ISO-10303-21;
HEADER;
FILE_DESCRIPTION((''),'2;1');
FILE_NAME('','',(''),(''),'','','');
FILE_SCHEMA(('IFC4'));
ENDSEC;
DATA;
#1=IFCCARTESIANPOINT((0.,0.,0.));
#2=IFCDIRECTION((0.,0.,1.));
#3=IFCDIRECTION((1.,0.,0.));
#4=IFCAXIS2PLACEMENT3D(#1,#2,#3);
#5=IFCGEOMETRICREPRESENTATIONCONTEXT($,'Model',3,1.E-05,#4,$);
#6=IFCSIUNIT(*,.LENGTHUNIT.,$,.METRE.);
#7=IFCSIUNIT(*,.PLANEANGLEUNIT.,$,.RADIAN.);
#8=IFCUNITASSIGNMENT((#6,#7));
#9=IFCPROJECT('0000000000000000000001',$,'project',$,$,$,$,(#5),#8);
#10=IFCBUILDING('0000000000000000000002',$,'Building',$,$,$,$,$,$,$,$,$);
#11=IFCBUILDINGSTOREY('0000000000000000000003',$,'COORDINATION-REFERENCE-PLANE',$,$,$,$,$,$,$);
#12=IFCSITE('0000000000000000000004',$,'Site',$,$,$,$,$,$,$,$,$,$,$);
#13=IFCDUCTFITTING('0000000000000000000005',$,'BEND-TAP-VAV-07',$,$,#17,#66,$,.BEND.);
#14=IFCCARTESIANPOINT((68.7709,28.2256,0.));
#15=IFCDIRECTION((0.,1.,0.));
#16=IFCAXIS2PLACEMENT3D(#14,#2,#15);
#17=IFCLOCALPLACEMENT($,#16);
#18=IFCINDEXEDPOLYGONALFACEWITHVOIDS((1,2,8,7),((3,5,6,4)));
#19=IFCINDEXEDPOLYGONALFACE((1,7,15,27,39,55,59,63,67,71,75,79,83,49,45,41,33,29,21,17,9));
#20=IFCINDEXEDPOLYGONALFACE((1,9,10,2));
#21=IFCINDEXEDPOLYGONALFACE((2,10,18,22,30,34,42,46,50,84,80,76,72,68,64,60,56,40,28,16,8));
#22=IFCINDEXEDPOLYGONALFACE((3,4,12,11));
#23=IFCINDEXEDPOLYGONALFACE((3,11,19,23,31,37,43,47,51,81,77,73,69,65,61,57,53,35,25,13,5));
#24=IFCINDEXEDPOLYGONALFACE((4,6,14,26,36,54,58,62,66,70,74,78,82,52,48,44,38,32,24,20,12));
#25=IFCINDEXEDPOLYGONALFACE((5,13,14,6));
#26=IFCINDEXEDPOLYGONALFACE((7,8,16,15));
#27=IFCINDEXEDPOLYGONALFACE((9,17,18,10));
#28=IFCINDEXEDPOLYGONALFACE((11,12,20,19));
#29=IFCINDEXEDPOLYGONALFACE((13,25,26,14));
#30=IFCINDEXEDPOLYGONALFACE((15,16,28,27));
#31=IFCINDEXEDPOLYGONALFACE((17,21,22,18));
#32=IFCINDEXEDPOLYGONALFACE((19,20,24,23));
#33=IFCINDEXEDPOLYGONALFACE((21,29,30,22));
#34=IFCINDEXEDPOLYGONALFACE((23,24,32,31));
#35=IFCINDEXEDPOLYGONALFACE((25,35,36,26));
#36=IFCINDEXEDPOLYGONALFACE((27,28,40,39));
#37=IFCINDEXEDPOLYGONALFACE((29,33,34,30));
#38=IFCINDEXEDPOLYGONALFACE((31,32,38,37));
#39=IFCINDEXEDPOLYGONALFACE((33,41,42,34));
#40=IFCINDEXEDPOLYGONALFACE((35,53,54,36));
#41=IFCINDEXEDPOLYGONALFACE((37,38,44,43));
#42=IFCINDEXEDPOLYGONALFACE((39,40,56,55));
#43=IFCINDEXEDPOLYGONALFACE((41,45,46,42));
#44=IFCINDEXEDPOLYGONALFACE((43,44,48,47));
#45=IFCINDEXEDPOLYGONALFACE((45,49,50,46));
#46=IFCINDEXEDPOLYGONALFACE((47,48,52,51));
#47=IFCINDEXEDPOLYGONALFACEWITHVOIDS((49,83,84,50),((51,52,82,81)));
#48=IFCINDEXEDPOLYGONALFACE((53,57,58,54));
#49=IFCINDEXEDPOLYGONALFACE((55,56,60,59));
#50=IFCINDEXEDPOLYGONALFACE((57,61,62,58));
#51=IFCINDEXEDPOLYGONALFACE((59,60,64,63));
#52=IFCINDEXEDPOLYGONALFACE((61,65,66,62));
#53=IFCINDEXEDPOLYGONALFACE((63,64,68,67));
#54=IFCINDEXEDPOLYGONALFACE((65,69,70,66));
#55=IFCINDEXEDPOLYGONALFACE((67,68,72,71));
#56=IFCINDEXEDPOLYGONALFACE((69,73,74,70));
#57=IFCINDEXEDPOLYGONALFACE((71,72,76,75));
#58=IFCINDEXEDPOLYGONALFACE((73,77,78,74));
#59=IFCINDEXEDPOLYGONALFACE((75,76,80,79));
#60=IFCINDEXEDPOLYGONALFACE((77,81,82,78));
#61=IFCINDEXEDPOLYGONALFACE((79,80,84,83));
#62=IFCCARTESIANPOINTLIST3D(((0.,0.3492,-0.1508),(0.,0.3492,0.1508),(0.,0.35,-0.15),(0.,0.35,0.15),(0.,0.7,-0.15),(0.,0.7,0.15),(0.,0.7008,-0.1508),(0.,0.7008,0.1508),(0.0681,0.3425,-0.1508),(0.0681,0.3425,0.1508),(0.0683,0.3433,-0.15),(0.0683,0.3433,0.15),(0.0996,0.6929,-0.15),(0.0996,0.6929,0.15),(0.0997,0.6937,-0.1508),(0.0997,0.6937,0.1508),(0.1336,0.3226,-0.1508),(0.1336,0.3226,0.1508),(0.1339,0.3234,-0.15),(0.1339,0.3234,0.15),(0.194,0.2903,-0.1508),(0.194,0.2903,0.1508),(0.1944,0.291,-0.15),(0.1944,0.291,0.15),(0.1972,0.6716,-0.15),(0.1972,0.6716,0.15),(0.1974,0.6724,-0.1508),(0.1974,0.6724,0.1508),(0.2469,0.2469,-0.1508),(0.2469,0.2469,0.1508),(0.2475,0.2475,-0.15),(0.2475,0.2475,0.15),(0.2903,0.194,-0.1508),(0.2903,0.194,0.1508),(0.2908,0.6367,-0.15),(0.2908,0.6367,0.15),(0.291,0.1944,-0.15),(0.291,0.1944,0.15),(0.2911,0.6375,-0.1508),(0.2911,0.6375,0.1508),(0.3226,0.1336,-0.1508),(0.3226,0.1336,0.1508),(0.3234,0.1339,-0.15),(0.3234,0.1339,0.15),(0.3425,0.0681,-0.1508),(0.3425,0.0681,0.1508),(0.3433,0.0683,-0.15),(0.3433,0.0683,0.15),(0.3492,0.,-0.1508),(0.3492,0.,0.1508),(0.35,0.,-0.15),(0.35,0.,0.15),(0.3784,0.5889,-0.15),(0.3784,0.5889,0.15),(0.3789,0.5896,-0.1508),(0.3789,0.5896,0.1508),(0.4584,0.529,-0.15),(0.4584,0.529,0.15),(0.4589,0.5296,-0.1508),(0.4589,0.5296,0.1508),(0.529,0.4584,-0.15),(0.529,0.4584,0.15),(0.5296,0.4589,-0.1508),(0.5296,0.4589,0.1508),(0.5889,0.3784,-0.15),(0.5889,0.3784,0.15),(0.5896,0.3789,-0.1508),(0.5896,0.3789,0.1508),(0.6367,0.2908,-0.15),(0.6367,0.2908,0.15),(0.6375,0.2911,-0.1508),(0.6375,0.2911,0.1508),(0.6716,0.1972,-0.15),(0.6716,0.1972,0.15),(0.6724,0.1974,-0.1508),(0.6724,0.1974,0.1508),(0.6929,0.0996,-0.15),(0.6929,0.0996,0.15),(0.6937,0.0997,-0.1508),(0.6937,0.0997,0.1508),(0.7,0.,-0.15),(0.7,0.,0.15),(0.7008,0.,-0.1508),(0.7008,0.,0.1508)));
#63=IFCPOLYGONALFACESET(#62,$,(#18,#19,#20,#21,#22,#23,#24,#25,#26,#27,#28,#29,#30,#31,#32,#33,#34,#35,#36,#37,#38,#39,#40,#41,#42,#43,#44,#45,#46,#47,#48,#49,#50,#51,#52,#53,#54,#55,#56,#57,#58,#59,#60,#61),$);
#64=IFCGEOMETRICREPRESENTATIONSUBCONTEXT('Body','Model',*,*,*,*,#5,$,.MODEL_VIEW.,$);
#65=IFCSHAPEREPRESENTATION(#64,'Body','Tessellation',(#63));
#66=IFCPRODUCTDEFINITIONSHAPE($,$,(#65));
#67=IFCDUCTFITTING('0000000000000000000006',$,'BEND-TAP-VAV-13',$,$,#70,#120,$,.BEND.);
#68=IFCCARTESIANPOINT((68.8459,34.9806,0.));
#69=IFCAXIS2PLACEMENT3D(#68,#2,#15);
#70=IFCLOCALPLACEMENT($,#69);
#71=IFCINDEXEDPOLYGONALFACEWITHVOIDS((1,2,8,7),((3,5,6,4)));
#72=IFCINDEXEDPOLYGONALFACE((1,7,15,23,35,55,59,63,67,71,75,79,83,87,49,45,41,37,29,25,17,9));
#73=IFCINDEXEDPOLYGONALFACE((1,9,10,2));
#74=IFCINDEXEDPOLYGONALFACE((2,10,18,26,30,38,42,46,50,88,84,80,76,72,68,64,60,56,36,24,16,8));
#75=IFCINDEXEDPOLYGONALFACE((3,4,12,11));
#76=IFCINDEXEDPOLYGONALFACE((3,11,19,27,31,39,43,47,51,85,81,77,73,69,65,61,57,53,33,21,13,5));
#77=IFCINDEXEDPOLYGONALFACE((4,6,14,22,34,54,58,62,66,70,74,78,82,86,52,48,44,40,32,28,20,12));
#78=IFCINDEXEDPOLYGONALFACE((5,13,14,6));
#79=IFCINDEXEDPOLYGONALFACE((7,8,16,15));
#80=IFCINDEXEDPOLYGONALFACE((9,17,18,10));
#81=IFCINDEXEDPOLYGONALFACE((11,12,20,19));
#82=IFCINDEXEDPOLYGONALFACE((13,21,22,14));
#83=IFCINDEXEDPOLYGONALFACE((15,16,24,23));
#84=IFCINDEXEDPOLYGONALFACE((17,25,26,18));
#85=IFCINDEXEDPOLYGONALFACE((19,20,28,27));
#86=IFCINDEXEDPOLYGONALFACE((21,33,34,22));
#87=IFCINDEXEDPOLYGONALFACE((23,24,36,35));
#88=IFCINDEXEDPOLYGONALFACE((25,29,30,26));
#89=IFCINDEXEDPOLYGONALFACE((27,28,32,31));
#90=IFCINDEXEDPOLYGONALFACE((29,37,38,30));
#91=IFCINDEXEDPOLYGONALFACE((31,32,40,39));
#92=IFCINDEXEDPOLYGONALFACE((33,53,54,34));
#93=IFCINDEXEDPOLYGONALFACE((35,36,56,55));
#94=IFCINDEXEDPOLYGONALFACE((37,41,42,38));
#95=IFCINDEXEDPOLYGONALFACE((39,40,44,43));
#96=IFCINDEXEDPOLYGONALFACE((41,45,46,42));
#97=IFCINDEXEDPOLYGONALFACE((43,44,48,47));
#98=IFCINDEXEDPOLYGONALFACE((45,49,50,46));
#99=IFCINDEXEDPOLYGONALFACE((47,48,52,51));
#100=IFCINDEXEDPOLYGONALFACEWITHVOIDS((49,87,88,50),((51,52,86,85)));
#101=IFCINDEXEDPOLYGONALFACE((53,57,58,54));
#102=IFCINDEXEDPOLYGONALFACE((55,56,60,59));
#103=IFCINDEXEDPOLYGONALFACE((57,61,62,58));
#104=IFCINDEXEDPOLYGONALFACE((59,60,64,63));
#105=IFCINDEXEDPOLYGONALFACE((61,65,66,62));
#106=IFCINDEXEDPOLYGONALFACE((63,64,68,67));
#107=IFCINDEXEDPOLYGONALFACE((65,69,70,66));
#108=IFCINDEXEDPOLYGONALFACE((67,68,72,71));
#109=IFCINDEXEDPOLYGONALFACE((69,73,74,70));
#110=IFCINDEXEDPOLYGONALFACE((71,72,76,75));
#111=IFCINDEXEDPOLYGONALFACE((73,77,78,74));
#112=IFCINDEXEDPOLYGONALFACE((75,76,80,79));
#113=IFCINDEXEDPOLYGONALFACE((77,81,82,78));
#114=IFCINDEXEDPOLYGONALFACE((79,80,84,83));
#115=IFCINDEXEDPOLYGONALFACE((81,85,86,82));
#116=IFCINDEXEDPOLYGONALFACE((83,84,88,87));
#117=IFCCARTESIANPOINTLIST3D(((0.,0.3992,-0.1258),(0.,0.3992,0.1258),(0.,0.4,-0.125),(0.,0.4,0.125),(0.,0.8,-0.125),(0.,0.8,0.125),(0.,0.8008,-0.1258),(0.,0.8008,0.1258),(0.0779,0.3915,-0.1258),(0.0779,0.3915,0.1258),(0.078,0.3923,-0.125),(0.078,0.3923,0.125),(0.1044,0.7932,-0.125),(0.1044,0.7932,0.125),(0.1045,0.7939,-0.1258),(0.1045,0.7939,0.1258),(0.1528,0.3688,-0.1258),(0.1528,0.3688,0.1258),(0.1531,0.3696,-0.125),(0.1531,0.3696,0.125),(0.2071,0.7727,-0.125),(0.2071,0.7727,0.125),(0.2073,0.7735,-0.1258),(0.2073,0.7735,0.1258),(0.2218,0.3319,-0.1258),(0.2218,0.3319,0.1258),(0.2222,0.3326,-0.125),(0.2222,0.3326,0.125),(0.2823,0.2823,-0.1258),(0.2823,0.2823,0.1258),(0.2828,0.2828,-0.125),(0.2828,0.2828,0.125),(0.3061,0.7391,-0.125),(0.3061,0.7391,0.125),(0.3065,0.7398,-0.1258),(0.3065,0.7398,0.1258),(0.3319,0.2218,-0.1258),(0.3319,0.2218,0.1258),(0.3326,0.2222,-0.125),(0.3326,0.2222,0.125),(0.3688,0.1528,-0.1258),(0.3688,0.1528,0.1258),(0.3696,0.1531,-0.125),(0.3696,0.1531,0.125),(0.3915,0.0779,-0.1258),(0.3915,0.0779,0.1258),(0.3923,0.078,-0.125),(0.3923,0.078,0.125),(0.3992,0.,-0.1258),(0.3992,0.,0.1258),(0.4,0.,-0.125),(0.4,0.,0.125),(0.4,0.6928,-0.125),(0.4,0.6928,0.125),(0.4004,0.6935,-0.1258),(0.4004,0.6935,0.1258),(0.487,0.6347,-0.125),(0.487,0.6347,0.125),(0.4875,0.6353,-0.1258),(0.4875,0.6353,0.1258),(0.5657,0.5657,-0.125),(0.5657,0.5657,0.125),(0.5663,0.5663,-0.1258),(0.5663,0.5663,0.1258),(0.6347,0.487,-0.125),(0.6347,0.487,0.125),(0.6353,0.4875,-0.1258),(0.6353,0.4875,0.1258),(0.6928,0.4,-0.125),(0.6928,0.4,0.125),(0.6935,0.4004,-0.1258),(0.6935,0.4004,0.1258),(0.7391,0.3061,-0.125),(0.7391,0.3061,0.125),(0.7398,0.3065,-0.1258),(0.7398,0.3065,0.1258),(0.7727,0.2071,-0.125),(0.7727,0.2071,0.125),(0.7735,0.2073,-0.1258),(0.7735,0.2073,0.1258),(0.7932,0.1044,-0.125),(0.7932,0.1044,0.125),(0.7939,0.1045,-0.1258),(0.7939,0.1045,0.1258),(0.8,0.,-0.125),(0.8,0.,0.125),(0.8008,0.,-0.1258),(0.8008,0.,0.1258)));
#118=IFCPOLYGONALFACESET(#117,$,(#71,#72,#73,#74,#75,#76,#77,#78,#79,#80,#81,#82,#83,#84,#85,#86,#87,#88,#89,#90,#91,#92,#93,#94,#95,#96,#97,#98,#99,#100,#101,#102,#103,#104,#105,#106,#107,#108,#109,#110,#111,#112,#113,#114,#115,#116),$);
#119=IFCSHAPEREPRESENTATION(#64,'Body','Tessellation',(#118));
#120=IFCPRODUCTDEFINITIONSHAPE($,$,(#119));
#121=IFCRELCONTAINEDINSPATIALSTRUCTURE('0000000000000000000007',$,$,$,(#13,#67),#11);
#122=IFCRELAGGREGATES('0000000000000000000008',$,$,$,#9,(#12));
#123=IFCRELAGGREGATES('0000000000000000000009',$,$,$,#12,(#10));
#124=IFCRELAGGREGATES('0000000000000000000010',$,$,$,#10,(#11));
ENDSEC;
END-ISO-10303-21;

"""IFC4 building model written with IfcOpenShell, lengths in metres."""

from ifc_helpers import new_model, entity, si_unit, frame, origin_with_axes, place, context, subcontext, project, spatial, element, save


model = new_model("IFC4")

# Units and contexts
model_context = context("Model", 3, precision=1e-05, world=origin_with_axes())
body_context_1 = subcontext(model_context, "Body", "Model", "MODEL_VIEW")
ifc_project = project(units=[si_unit("LENGTHUNIT", "METRE"), si_unit("PLANEANGLEUNIT", "RADIAN")], contexts=[model_context])

# Site, building, storey
site = spatial("IfcSite", under=ifc_project, Name="Site")
building = spatial("IfcBuilding", under=site, Name="Building")
storey = spatial("IfcBuildingStorey", under=building, Name="COORDINATION-REFERENCE-PLANE")

# Duct fittings
duct_fitting_1_placement = place(None, frame((68.7709, 28.2256, 0.0), z_axis=(0.0, 0.0, 1.0), x_axis=(0.0, 1.0, 0.0)))
cartesian_point_1 = entity("IfcCartesianPoint", [0.0, 0.0, 0.0])
element("IfcDuctFitting", 1, at=duct_fitting_1_placement, inside=storey, Name="BEND-TAP-VAV-07", PredefinedType="BEND", context=body_context_1, shape_type="SweptSolid", body=[
    entity("IfcRevolvedAreaSolid", entity("IfcRectangleHollowProfileDef", "AREA", None, entity("IfcAxis2Placement2D", entity("IfcCartesianPoint", [0.525, 0.0])), 0.3516, 0.3016, 0.0008), entity("IfcAxis2Placement3D", cartesian_point_1, entity("IfcDirection", [0.0, -1.0, 0.0]), entity("IfcDirection", [1.0, 0.0, 0.0])), entity("IfcAxis1Placement", cartesian_point_1, entity("IfcDirection", [0.0, 1.0, 0.0])), 1.570796),
])
duct_fitting_2_placement = place(None, frame((68.8459, 34.9806, 0.0), z_axis=(0.0, 0.0, 1.0), x_axis=(0.0, 1.0, 0.0)))
cartesian_point_2 = entity("IfcCartesianPoint", [0.0, 0.0, 0.0])
element("IfcDuctFitting", 2, at=duct_fitting_2_placement, inside=storey, Name="BEND-TAP-VAV-13", PredefinedType="BEND", context=body_context_1, shape_type="SweptSolid", body=[
    entity("IfcRevolvedAreaSolid", entity("IfcRectangleHollowProfileDef", "AREA", None, entity("IfcAxis2Placement2D", entity("IfcCartesianPoint", [0.6, 0.0])), 0.4016, 0.2516, 0.0008), entity("IfcAxis2Placement3D", cartesian_point_2, entity("IfcDirection", [0.0, -1.0, 0.0]), entity("IfcDirection", [1.0, 0.0, 0.0])), entity("IfcAxis1Placement", cartesian_point_2, entity("IfcDirection", [0.0, 1.0, 0.0])), 1.570796),
])

save(model, "model.ifc")
